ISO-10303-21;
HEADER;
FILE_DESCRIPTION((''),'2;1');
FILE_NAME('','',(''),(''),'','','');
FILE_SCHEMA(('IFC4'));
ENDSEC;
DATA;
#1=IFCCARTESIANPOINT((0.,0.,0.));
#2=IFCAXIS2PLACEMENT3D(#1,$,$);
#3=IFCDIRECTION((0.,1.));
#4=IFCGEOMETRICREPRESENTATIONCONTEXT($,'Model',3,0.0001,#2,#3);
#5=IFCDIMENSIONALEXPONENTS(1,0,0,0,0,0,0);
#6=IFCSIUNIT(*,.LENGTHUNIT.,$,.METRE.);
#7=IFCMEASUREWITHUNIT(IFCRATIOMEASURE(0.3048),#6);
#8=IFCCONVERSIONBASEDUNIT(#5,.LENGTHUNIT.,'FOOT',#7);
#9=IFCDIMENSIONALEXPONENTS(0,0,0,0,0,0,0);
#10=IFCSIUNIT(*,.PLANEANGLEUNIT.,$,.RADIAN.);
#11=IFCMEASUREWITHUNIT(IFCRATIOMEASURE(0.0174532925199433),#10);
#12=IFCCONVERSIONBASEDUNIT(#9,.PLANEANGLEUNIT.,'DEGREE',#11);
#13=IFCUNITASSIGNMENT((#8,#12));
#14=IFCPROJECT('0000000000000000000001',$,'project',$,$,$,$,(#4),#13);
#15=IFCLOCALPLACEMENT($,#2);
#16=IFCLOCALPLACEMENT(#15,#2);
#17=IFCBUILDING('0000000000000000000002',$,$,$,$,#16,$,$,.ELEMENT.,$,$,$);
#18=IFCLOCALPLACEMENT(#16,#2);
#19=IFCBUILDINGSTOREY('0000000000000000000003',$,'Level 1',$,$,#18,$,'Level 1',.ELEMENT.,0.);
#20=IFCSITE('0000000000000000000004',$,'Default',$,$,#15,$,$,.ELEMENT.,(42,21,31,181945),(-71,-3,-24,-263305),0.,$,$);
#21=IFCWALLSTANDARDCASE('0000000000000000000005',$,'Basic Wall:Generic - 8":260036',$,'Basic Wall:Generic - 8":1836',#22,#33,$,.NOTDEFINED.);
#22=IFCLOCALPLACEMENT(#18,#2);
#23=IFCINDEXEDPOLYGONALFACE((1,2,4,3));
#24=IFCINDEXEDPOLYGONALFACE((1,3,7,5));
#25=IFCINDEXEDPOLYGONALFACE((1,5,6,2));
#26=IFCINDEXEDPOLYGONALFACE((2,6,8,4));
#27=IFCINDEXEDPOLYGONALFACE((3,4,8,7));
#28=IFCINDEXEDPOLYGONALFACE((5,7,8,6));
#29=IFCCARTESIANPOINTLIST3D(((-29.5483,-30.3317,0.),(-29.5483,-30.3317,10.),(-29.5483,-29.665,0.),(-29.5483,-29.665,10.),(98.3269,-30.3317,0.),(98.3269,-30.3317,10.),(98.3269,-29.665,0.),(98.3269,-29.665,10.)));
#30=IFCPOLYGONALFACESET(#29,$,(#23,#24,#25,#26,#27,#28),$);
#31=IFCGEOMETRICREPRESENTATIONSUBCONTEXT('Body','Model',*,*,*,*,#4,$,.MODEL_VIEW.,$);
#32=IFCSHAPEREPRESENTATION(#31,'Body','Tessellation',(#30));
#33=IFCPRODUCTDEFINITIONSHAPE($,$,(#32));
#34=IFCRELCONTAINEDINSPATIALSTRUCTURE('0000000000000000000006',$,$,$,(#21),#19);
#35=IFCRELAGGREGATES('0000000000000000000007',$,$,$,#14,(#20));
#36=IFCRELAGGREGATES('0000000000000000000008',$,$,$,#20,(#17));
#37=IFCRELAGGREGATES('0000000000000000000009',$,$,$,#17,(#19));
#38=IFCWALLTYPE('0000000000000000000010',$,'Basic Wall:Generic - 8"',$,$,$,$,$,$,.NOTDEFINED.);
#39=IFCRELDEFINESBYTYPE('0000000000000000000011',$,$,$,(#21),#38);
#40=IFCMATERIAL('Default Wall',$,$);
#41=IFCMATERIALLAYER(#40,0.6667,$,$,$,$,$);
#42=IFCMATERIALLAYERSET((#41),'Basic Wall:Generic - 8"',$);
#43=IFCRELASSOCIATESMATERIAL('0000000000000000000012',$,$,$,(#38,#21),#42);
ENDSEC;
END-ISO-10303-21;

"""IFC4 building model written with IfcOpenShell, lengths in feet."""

from ifc_helpers import new_model, entity, si_unit, converted_unit, direction, frame, frame_2d, origin, place, context, subcontext, project, spatial, rectangle, extrude, material, layer, layer_set, layer_usage, type_object, element, save


model = new_model("IFC4")

# Units and contexts
model_context = context("Model", 3, precision=0.0001, world=origin(), true_north=direction((0.0, 1.0)))
body_context = subcontext(model_context, "Body", "Model", "MODEL_VIEW")
ifc_project = project(units=[converted_unit("LENGTHUNIT", "FOOT", entity("IfcRatioMeasure", 0.3048), si_unit("LENGTHUNIT", "METRE"), dimensions=[1, 0, 0, 0, 0, 0, 0]), converted_unit("PLANEANGLEUNIT", "DEGREE", entity("IfcRatioMeasure", 0.0174532925199433), si_unit("PLANEANGLEUNIT", "RADIAN"), dimensions=[0, 0, 0, 0, 0, 0, 0])], contexts=[model_context])

# Site, building, storey
site_placement = place(None, origin())
site = spatial("IfcSite", under=ifc_project, at=site_placement, Name="Default", CompositionType="ELEMENT", RefLatitude=(42, 21, 31, 181945), RefLongitude=(-71, -3, -24, -263305), RefElevation=0.0)
building_placement = place(site_placement, origin())
building = spatial("IfcBuilding", under=site, at=building_placement, CompositionType="ELEMENT")
storey_placement = place(building_placement, origin())
storey = spatial("IfcBuildingStorey", under=building, at=storey_placement, Name="Level 1", LongName="Level 1", CompositionType="ELEMENT", Elevation=0.0)

# Wall
ifc_material_1 = material(Name="Default Wall")
ifc_layer = layer(ifc_material_1, 0.6667)
ifc_layer_set = layer_set([ifc_layer], Name="Basic Wall:Generic - 8\"")
ifc_layer_usage = layer_usage(ifc_layer_set, "AXIS2", "NEGATIVE", 0.3333)
wall_type = type_object("IfcWallType", Name="Basic Wall:Generic - 8\"", PredefinedType="NOTDEFINED", material=ifc_layer_set)
wall_placement = place(storey_placement, frame((98.3269, -29.9983, 0.0), z_axis=(0.0, 0.0, 1.0), x_axis=(-1.0, 0.0, 0.0)))
element("IfcWallStandardCase", 1, at=wall_placement, inside=storey, type_object=wall_type, material=ifc_layer_usage, Name="Basic Wall:Generic - 8\":260036", ObjectType="Basic Wall:Generic - 8\":1836", PredefinedType="NOTDEFINED", context=body_context, shape_type="SweptSolid", body=[
    extrude(rectangle(XDim=127.8752, YDim=0.6667, at=frame_2d((63.9376, 0.0), x_axis=(-1.0, 0.0))), origin(), (0.0, 0.0, 1.0), 10.0),
])

save(model, "model.ifc")
